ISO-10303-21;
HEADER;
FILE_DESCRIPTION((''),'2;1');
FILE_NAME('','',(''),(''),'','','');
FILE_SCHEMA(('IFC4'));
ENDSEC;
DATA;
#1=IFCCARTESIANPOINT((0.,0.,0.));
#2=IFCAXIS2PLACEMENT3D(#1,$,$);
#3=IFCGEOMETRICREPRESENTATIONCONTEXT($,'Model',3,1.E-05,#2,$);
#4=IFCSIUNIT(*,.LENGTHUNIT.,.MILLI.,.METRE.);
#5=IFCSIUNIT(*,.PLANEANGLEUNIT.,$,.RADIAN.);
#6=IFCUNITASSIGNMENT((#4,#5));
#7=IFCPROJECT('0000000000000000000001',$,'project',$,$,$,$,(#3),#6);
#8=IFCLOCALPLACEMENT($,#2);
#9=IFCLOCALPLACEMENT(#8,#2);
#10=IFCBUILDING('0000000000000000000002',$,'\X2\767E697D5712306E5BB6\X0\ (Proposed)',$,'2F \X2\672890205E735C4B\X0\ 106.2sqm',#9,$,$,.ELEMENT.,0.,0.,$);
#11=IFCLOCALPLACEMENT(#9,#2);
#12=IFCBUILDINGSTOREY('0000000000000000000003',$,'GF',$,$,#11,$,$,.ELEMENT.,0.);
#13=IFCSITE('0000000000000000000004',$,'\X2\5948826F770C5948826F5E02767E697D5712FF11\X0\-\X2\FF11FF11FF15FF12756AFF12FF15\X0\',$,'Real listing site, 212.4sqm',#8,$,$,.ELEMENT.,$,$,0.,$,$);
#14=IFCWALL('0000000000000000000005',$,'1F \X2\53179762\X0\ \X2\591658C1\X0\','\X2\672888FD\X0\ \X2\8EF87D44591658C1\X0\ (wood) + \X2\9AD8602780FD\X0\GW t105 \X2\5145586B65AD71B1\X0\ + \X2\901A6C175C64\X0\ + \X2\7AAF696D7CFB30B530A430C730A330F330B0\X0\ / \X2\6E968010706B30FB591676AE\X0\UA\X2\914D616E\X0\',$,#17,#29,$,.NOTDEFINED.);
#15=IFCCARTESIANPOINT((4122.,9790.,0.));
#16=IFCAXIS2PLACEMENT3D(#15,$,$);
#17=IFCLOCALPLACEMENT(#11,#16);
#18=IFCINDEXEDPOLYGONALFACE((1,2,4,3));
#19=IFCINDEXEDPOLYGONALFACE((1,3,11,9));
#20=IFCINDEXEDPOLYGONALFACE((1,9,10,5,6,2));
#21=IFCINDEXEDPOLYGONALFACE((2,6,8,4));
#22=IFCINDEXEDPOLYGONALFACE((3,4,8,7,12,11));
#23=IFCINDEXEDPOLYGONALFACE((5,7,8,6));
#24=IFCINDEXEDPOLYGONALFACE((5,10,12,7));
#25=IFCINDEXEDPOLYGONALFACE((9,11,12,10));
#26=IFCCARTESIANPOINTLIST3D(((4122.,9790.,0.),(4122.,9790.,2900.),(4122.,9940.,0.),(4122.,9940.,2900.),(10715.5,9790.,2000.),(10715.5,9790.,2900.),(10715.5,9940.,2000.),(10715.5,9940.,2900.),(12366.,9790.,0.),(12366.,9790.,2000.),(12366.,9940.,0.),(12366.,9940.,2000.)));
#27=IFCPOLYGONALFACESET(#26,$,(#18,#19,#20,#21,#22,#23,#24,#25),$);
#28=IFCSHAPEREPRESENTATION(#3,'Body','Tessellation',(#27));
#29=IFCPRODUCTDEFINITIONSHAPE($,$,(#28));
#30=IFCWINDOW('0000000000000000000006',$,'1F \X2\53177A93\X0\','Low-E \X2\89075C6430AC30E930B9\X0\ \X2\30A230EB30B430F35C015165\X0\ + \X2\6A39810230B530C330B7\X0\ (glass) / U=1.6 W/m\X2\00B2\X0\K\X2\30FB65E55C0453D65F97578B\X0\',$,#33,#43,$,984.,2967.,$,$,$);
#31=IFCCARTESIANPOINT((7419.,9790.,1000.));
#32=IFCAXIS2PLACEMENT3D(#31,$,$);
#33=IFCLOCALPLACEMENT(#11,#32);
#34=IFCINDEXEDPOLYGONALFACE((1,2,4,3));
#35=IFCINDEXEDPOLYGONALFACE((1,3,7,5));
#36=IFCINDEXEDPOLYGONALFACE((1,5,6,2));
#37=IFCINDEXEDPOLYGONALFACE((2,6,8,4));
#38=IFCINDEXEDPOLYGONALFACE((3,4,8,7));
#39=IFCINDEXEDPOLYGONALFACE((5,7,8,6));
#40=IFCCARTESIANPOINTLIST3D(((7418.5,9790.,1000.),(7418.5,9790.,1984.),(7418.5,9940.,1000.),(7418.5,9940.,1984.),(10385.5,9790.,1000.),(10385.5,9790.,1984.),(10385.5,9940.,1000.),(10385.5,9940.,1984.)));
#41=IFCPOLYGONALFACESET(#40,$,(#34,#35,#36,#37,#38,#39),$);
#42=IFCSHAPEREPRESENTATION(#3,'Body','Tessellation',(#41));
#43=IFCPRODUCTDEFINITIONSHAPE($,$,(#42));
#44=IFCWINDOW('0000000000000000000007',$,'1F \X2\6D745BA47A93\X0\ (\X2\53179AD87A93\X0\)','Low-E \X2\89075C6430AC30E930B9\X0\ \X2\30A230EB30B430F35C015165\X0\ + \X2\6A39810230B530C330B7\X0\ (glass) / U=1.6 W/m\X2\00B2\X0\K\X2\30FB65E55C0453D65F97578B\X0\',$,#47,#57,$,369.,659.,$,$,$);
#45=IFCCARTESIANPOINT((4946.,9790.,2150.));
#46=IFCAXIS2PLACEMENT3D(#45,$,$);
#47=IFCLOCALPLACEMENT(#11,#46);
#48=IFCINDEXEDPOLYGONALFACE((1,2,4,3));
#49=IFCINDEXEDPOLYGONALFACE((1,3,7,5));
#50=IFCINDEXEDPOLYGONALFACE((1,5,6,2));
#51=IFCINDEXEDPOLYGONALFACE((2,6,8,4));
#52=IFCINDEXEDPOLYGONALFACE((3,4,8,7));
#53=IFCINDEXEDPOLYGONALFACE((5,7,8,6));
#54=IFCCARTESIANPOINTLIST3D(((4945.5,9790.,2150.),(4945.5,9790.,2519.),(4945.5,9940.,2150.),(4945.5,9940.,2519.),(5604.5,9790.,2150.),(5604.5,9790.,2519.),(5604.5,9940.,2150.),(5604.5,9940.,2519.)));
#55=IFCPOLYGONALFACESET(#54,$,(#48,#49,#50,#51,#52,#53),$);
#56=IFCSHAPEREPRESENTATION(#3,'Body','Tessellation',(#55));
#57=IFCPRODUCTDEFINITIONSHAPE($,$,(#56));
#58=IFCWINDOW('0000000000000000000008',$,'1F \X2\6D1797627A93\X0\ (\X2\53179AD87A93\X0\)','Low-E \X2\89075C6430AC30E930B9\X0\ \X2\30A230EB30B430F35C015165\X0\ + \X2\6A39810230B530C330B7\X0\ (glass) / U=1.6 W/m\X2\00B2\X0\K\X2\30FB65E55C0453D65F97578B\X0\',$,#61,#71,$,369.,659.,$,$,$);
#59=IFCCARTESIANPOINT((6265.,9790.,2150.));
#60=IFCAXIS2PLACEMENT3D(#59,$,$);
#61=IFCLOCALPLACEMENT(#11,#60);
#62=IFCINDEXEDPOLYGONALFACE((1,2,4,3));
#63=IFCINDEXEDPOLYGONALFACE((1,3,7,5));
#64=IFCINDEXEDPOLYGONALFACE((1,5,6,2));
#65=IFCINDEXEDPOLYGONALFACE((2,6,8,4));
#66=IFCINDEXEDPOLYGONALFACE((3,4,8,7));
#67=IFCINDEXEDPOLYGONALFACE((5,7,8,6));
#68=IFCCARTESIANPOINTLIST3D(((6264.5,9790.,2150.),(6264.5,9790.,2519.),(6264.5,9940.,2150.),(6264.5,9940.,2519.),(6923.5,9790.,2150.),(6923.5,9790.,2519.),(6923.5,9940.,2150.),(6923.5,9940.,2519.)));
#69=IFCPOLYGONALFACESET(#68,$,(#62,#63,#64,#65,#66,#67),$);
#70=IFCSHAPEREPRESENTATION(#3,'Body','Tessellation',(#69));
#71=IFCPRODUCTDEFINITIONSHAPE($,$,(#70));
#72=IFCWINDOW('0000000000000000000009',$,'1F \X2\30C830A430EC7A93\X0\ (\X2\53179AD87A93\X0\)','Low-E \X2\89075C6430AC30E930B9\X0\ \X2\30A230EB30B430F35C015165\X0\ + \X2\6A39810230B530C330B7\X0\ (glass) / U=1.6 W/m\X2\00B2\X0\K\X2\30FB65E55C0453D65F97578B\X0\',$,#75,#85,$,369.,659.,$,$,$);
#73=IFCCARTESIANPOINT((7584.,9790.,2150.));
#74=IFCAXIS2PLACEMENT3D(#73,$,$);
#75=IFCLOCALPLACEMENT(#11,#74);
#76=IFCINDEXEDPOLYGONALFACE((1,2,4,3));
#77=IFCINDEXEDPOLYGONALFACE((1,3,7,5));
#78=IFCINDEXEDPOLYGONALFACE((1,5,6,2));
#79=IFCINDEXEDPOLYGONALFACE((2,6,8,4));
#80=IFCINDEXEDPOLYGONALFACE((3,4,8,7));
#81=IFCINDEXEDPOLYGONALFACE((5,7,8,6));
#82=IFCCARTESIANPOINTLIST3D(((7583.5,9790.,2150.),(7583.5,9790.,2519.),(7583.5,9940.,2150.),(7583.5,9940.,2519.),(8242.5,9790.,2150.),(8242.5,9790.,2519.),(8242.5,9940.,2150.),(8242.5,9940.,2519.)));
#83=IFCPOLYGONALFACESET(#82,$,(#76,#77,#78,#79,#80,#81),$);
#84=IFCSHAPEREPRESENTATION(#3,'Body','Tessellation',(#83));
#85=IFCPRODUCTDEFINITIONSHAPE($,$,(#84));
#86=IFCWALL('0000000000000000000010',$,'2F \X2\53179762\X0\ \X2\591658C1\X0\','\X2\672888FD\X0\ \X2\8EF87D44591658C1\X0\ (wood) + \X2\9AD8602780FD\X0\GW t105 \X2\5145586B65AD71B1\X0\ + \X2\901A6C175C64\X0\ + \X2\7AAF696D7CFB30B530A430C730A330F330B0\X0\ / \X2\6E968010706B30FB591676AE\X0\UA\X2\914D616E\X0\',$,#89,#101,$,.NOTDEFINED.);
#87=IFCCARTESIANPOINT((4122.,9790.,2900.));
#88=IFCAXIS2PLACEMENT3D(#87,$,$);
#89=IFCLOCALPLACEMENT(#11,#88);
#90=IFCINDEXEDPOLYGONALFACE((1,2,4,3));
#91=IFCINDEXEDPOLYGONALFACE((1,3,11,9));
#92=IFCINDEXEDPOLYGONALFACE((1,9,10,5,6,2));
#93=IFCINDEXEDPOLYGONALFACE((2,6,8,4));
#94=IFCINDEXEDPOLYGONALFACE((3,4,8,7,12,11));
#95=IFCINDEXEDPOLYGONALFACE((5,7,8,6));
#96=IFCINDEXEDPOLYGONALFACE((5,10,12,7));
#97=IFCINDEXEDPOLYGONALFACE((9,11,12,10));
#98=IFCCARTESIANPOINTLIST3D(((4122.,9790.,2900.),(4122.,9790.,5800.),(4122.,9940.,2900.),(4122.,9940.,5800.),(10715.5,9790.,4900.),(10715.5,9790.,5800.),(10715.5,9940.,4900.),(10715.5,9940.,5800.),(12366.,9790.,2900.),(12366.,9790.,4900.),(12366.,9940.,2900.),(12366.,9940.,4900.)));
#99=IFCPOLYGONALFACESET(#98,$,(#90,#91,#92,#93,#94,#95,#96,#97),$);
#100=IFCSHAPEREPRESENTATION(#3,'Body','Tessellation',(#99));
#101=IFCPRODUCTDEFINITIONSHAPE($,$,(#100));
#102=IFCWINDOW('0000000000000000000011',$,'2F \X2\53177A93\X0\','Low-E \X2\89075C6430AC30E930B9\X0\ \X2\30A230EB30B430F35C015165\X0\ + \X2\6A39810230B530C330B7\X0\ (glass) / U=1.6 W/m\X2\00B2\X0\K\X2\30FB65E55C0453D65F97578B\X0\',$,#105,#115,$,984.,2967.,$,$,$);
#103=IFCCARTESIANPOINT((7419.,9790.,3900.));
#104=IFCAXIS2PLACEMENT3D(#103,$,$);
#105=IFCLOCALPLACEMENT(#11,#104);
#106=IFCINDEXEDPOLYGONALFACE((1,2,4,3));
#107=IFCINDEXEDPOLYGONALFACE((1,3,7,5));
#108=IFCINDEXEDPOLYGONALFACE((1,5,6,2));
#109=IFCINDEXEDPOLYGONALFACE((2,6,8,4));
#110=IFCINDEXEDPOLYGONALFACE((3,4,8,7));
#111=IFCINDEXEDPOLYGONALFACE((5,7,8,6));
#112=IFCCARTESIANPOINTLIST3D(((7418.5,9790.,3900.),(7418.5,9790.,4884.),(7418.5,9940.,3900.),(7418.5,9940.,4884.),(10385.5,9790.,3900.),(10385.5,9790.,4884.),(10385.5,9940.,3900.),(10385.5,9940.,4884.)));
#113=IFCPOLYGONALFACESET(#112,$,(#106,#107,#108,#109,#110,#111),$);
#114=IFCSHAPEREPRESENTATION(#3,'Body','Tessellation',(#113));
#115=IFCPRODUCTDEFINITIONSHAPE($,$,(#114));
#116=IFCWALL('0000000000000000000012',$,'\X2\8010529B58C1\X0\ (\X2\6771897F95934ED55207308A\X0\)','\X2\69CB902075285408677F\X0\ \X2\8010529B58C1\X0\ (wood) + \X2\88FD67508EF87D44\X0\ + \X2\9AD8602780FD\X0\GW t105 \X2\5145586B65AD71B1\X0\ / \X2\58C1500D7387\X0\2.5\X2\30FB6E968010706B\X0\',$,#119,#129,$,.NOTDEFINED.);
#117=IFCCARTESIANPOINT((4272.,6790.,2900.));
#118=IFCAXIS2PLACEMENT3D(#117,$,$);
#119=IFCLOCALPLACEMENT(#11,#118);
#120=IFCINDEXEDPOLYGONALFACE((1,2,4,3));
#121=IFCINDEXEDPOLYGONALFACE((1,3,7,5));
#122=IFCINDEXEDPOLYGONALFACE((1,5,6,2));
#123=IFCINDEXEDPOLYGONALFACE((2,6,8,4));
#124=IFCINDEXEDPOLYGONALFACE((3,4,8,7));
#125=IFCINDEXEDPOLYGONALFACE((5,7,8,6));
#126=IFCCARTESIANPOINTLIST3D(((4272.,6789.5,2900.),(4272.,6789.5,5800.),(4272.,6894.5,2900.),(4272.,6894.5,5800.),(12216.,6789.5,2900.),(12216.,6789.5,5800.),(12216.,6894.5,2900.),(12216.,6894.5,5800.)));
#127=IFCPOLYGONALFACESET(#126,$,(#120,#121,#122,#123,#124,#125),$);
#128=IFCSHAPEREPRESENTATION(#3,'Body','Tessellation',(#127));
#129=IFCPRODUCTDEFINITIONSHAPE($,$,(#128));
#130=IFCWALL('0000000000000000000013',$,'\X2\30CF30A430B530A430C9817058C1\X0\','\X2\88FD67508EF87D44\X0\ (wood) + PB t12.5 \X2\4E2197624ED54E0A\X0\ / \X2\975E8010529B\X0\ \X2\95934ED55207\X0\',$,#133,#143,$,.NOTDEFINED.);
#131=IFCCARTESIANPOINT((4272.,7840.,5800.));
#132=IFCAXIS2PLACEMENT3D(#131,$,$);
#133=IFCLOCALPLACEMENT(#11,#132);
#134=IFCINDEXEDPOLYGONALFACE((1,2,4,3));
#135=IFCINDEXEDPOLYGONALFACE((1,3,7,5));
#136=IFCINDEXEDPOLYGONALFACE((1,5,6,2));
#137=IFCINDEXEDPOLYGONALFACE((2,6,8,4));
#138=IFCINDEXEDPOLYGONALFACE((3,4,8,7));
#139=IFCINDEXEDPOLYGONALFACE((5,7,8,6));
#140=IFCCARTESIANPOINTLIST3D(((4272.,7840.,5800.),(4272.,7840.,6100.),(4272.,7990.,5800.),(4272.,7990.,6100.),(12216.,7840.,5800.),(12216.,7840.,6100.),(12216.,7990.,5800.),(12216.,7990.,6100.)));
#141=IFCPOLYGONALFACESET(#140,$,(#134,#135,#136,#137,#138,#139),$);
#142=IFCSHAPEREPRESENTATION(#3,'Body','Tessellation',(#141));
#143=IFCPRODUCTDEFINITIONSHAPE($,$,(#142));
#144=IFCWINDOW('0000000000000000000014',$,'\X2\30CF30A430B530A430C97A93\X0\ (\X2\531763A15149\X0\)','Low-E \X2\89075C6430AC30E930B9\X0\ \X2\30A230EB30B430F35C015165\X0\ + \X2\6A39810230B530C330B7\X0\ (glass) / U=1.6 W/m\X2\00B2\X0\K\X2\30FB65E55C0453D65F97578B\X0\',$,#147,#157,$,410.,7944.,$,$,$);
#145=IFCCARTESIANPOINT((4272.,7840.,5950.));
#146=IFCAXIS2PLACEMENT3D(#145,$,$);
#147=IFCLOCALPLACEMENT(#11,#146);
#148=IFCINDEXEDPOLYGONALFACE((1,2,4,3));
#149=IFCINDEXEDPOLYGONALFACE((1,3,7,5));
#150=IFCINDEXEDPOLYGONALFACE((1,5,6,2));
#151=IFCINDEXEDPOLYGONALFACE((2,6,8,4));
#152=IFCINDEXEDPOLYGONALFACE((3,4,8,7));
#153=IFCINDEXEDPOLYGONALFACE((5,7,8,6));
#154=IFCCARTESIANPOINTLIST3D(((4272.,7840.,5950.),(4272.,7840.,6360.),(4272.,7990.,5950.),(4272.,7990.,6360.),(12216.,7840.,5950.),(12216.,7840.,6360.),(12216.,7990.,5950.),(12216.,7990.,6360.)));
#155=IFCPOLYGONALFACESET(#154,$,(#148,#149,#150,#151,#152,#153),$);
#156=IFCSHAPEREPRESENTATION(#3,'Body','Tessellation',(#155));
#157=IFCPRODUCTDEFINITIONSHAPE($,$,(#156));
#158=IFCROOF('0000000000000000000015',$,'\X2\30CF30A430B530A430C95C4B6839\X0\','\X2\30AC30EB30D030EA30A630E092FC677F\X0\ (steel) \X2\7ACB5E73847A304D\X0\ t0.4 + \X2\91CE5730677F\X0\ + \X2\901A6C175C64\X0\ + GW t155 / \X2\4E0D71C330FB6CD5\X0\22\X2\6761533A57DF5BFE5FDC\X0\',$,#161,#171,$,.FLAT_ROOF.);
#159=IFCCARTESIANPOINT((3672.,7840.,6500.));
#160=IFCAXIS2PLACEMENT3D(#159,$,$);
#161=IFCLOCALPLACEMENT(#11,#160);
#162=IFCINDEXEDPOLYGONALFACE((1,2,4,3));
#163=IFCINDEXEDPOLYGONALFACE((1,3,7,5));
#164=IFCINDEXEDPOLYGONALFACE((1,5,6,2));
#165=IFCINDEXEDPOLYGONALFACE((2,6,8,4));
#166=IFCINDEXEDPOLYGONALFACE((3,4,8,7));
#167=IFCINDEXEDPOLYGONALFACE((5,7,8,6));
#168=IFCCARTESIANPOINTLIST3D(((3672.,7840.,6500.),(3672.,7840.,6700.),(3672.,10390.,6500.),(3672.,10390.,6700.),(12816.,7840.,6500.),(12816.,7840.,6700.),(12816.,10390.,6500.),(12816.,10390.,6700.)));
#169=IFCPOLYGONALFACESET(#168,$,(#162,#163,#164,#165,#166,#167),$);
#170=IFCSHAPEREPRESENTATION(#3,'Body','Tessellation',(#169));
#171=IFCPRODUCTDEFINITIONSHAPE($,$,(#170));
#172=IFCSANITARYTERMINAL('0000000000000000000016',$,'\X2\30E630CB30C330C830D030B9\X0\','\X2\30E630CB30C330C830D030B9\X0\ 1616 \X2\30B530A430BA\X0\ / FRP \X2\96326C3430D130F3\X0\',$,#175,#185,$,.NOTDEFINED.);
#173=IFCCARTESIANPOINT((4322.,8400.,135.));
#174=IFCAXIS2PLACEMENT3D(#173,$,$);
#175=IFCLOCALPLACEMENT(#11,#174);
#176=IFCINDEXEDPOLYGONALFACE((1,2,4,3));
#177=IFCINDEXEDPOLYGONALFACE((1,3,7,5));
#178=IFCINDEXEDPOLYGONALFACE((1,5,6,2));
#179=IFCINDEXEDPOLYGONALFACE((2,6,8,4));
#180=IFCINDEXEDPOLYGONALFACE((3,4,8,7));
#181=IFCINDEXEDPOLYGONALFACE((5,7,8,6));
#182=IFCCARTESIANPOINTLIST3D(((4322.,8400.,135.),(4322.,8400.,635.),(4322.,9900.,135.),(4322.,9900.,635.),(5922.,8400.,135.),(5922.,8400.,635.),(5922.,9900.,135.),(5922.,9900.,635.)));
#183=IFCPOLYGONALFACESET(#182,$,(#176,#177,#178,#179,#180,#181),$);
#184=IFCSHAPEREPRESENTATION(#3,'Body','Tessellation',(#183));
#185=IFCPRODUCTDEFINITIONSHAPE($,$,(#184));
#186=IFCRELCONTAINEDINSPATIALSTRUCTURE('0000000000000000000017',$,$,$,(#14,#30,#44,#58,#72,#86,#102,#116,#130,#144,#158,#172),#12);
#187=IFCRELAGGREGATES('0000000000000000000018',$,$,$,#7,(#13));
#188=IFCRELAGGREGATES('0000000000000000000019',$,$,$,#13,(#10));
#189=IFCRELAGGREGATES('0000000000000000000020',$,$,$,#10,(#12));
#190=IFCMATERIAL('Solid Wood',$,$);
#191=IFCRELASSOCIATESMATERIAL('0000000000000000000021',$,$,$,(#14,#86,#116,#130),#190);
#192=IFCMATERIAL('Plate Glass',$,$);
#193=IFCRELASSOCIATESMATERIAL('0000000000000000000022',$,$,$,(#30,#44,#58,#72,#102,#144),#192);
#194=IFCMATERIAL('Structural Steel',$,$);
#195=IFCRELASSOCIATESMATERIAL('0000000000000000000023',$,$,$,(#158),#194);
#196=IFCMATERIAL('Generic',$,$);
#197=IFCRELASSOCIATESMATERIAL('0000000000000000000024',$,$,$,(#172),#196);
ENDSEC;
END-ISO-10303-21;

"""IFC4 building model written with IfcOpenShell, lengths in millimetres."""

from ifc_helpers import new_model, si_unit, frame, frame_2d, origin, place, context, project, spatial, rectangle, extrude, material, element, fill, save


model = new_model("IFC4")

# Units and contexts
model_context = context("Model", 3, precision=1e-05, world=origin())
ifc_project = project(units=[si_unit("LENGTHUNIT", "METRE", prefix="MILLI"), si_unit("PLANEANGLEUNIT", "RADIAN")], contexts=[model_context])

# Site, building, storey
site_placement = place(None, origin())
site = spatial("IfcSite", under=ifc_project, at=site_placement, Name="奈良県奈良市百楽園１-１１５２番２５", ObjectType="Real listing site, 212.4sqm", CompositionType="ELEMENT", RefElevation=0.0)
building_placement = place(site_placement, origin())
building = spatial("IfcBuilding", under=site, at=building_placement, Name="百楽園の家 (Proposed)", ObjectType="2F 木造平屋 106.2sqm", CompositionType="ELEMENT", ElevationOfRefHeight=0.0, ElevationOfTerrain=0.0)
storey_placement = place(building_placement, origin())
storey = spatial("IfcBuildingStorey", under=building, at=storey_placement, Name="GF", CompositionType="ELEMENT", Elevation=0.0)

# Wall, openings, windows
ifc_material_1 = material(Name="Solid Wood")
wall_1_placement = place(storey_placement, frame((4122.0, 9790.0, 0.0)))
wall_1 = element("IfcWall", 1, at=wall_1_placement, inside=storey, material=ifc_material_1, Name="1F 北面 外壁", Description="木製 軸組外壁 (wood) + 高性能GW t105 充填断熱 + 通気層 + 窯業系サイディング / 準耐火・外皮UA配慮", PredefinedType="NOTDEFINED", context=model_context, shape_type="SweptSolid", body=[
    extrude(rectangle(XDim=8244.0, YDim=150.0, at=frame_2d((4122.0, 75.0))), frame((4122.0, 9790.0, 0.0)), (0.0, 0.0, 1.0), 2900.0),
])
opening_1_placement = place(storey_placement, frame((7419.0, 9790.0, 1000.0)))
opening_1 = element("IfcOpeningElement", 2, at=opening_1_placement, cuts=wall_1, PredefinedType="NOTDEFINED", context=model_context, shape_type="SweptSolid", body=[
    extrude(rectangle(XDim=2967.0, YDim=150.0, at=frame_2d((1483.0, 75.0))), frame((7419.0, 9790.0, 1000.0)), (0.0, 0.0, 1.0), 984.0),
])
opening_2_placement = place(storey_placement, frame((4946.0, 9790.0, 2150.0)))
opening_2 = element("IfcOpeningElement", 3, at=opening_2_placement, cuts=wall_1, PredefinedType="NOTDEFINED", context=model_context, shape_type="SweptSolid", body=[
    extrude(rectangle(XDim=659.0, YDim=150.0, at=frame_2d((329.0, 75.0))), frame((4946.0, 9790.0, 2150.0)), (0.0, 0.0, 1.0), 369.0),
])
opening_3_placement = place(storey_placement, frame((6265.0, 9790.0, 2150.0)))
opening_3 = element("IfcOpeningElement", 4, at=opening_3_placement, cuts=wall_1, PredefinedType="NOTDEFINED", context=model_context, shape_type="SweptSolid", body=[
    extrude(rectangle(XDim=659.0, YDim=150.0, at=frame_2d((329.0, 75.0))), frame((6265.0, 9790.0, 2150.0)), (0.0, 0.0, 1.0), 369.0),
])
opening_4_placement = place(storey_placement, frame((7584.0, 9790.0, 2150.0)))
opening_4 = element("IfcOpeningElement", 5, at=opening_4_placement, cuts=wall_1, PredefinedType="NOTDEFINED", context=model_context, shape_type="SweptSolid", body=[
    extrude(rectangle(XDim=659.0, YDim=150.0, at=frame_2d((329.0, 75.0))), frame((7584.0, 9790.0, 2150.0)), (0.0, 0.0, 1.0), 369.0),
])
ifc_material_2 = material(Name="Plate Glass")
window_1_placement = place(storey_placement, frame((7419.0, 9790.0, 1000.0)))
window_1 = element("IfcWindow", 6, at=window_1_placement, inside=storey, material=ifc_material_2, Name="1F 北窓", Description="Low-E 複層ガラス アルゴン封入 + 樹脂サッシ (glass) / U=1.6 W/m²K・日射取得型", OverallHeight=984.0, OverallWidth=2967.0, context=model_context, shape_type="SweptSolid", body=[
    extrude(rectangle(XDim=2967.0, YDim=150.0, at=frame_2d((1483.0, 75.0))), frame((7419.0, 9790.0, 1000.0)), (0.0, 0.0, 1.0), 984.0),
])
fill(opening_1, window_1)
window_2_placement = place(storey_placement, frame((4946.0, 9790.0, 2150.0)))
window_2 = element("IfcWindow", 7, at=window_2_placement, inside=storey, material=ifc_material_2, Name="1F 浴室窓 (北高窓)", Description="Low-E 複層ガラス アルゴン封入 + 樹脂サッシ (glass) / U=1.6 W/m²K・日射取得型", OverallHeight=369.0, OverallWidth=659.0, context=model_context, shape_type="SweptSolid", body=[
    extrude(rectangle(XDim=659.0, YDim=150.0, at=frame_2d((329.0, 75.0))), frame((4946.0, 9790.0, 2150.0)), (0.0, 0.0, 1.0), 369.0),
])
fill(opening_2, window_2)
window_3_placement = place(storey_placement, frame((6265.0, 9790.0, 2150.0)))
window_3 = element("IfcWindow", 8, at=window_3_placement, inside=storey, material=ifc_material_2, Name="1F 洗面窓 (北高窓)", Description="Low-E 複層ガラス アルゴン封入 + 樹脂サッシ (glass) / U=1.6 W/m²K・日射取得型", OverallHeight=369.0, OverallWidth=659.0, context=model_context, shape_type="SweptSolid", body=[
    extrude(rectangle(XDim=659.0, YDim=150.0, at=frame_2d((329.0, 75.0))), frame((6265.0, 9790.0, 2150.0)), (0.0, 0.0, 1.0), 369.0),
])
fill(opening_3, window_3)
window_4_placement = place(storey_placement, frame((7584.0, 9790.0, 2150.0)))
window_4 = element("IfcWindow", 9, at=window_4_placement, inside=storey, material=ifc_material_2, Name="1F トイレ窓 (北高窓)", Description="Low-E 複層ガラス アルゴン封入 + 樹脂サッシ (glass) / U=1.6 W/m²K・日射取得型", OverallHeight=369.0, OverallWidth=659.0, context=model_context, shape_type="SweptSolid", body=[
    extrude(rectangle(XDim=659.0, YDim=150.0, at=frame_2d((329.0, 75.0))), frame((7584.0, 9790.0, 2150.0)), (0.0, 0.0, 1.0), 369.0),
])
fill(opening_4, window_4)

# Wall, opening, window
wall_2_placement = place(storey_placement, frame((4122.0, 9790.0, 2900.0)))
wall_2 = element("IfcWall", 10, at=wall_2_placement, inside=storey, material=ifc_material_1, Name="2F 北面 外壁", Description="木製 軸組外壁 (wood) + 高性能GW t105 充填断熱 + 通気層 + 窯業系サイディング / 準耐火・外皮UA配慮", PredefinedType="NOTDEFINED", context=model_context, shape_type="SweptSolid", body=[
    extrude(rectangle(XDim=8244.0, YDim=150.0, at=frame_2d((4122.0, 75.0))), frame((4122.0, 9790.0, 2900.0)), (0.0, 0.0, 1.0), 2900.0),
])
opening_5_placement = place(storey_placement, frame((7419.0, 9790.0, 3900.0)))
opening_5 = element("IfcOpeningElement", 11, at=opening_5_placement, cuts=wall_2, PredefinedType="NOTDEFINED", context=model_context, shape_type="SweptSolid", body=[
    extrude(rectangle(XDim=2967.0, YDim=150.0, at=frame_2d((1483.0, 75.0))), frame((7419.0, 9790.0, 3900.0)), (0.0, 0.0, 1.0), 984.0),
])
window_5_placement = place(storey_placement, frame((7419.0, 9790.0, 3900.0)))
window_5 = element("IfcWindow", 12, at=window_5_placement, inside=storey, material=ifc_material_2, Name="2F 北窓", Description="Low-E 複層ガラス アルゴン封入 + 樹脂サッシ (glass) / U=1.6 W/m²K・日射取得型", OverallHeight=984.0, OverallWidth=2967.0, context=model_context, shape_type="SweptSolid", body=[
    extrude(rectangle(XDim=2967.0, YDim=150.0, at=frame_2d((1483.0, 75.0))), frame((7419.0, 9790.0, 3900.0)), (0.0, 0.0, 1.0), 984.0),
])
fill(opening_5, window_5)

# Wall
wall_3_placement = place(storey_placement, frame((4272.0, 6790.0, 2900.0)))
element("IfcWall", 13, at=wall_3_placement, inside=storey, material=ifc_material_1, Name="耐力壁 (東西間仕切り)", Description="構造用合板 耐力壁 (wood) + 製材軸組 + 高性能GW t105 充填断熱 / 壁倍率2.5・準耐火", PredefinedType="NOTDEFINED", context=model_context, shape_type="SweptSolid", body=[
    extrude(rectangle(XDim=7944.0, YDim=105.0, at=frame_2d((3972.0, 52.0))), frame((4272.0, 6790.0, 2900.0)), (0.0, 0.0, 1.0), 2900.0),
])

# Wall, opening, window
wall_4_placement = place(storey_placement, frame((4272.0, 7840.0, 5800.0)))
wall_4 = element("IfcWall", 14, at=wall_4_placement, inside=storey, material=ifc_material_1, Name="ハイサイド腰壁", Description="製材軸組 (wood) + PB t12.5 両面仕上 / 非耐力 間仕切", PredefinedType="NOTDEFINED", context=model_context, shape_type="SweptSolid", body=[
    extrude(rectangle(XDim=7944.0, YDim=150.0, at=frame_2d((3972.0, 75.0))), frame((4272.0, 7840.0, 5800.0)), (0.0, 0.0, 1.0), 700.0),
])
opening_6_placement = place(storey_placement, frame((4272.0, 7840.0, 5950.0)))
opening_6 = element("IfcOpeningElement", 15, at=opening_6_placement, cuts=wall_4, PredefinedType="NOTDEFINED", context=model_context, shape_type="SweptSolid", body=[
    extrude(rectangle(XDim=7944.0, YDim=150.0, at=frame_2d((3972.0, 75.0))), frame((4272.0, 7840.0, 5950.0)), (0.0, 0.0, 1.0), 410.0),
])
window_6_placement = place(storey_placement, frame((4272.0, 7840.0, 5950.0)))
window_6 = element("IfcWindow", 16, at=window_6_placement, inside=storey, material=ifc_material_2, Name="ハイサイド窓 (北採光)", Description="Low-E 複層ガラス アルゴン封入 + 樹脂サッシ (glass) / U=1.6 W/m²K・日射取得型", OverallHeight=410.0, OverallWidth=7944.0, context=model_context, shape_type="SweptSolid", body=[
    extrude(rectangle(XDim=7944.0, YDim=150.0, at=frame_2d((3972.0, 75.0))), frame((4272.0, 7840.0, 5950.0)), (0.0, 0.0, 1.0), 410.0),
])
fill(opening_6, window_6)

# Roof
ifc_material_3 = material(Name="Structural Steel")
roof_placement = place(storey_placement, frame((3672.0, 7840.0, 6500.0)))
element("IfcRoof", 17, at=roof_placement, inside=storey, material=ifc_material_3, Name="ハイサイド屋根", Description="ガルバリウム鋼板 (steel) 立平葺き t0.4 + 野地板 + 通気層 + GW t155 / 不燃・法22条区域対応", PredefinedType="FLAT_ROOF", context=model_context, shape_type="SweptSolid", body=[
    extrude(rectangle(XDim=9144.0, YDim=2550.0, at=frame_2d((4572.0, 1275.0))), frame((3672.0, 7840.0, 6500.0)), (0.0, 0.0, 1.0), 200.0),
])

# Sanitary terminal
ifc_material_4 = material(Name="Generic")
sanitary_terminal_placement = place(storey_placement, frame((4322.0, 8400.0, 135.0)))
element("IfcSanitaryTerminal", 18, at=sanitary_terminal_placement, inside=storey, material=ifc_material_4, Name="ユニットバス", Description="ユニットバス 1616 サイズ / FRP 防水パン", PredefinedType="NOTDEFINED", context=model_context, shape_type="SweptSolid", body=[
    extrude(rectangle(XDim=1600.0, YDim=1500.0, at=frame_2d((800.0, 750.0))), frame((4322.0, 8400.0, 135.0)), (0.0, 0.0, 1.0), 500.0),
])

save(model, "model.ifc")
